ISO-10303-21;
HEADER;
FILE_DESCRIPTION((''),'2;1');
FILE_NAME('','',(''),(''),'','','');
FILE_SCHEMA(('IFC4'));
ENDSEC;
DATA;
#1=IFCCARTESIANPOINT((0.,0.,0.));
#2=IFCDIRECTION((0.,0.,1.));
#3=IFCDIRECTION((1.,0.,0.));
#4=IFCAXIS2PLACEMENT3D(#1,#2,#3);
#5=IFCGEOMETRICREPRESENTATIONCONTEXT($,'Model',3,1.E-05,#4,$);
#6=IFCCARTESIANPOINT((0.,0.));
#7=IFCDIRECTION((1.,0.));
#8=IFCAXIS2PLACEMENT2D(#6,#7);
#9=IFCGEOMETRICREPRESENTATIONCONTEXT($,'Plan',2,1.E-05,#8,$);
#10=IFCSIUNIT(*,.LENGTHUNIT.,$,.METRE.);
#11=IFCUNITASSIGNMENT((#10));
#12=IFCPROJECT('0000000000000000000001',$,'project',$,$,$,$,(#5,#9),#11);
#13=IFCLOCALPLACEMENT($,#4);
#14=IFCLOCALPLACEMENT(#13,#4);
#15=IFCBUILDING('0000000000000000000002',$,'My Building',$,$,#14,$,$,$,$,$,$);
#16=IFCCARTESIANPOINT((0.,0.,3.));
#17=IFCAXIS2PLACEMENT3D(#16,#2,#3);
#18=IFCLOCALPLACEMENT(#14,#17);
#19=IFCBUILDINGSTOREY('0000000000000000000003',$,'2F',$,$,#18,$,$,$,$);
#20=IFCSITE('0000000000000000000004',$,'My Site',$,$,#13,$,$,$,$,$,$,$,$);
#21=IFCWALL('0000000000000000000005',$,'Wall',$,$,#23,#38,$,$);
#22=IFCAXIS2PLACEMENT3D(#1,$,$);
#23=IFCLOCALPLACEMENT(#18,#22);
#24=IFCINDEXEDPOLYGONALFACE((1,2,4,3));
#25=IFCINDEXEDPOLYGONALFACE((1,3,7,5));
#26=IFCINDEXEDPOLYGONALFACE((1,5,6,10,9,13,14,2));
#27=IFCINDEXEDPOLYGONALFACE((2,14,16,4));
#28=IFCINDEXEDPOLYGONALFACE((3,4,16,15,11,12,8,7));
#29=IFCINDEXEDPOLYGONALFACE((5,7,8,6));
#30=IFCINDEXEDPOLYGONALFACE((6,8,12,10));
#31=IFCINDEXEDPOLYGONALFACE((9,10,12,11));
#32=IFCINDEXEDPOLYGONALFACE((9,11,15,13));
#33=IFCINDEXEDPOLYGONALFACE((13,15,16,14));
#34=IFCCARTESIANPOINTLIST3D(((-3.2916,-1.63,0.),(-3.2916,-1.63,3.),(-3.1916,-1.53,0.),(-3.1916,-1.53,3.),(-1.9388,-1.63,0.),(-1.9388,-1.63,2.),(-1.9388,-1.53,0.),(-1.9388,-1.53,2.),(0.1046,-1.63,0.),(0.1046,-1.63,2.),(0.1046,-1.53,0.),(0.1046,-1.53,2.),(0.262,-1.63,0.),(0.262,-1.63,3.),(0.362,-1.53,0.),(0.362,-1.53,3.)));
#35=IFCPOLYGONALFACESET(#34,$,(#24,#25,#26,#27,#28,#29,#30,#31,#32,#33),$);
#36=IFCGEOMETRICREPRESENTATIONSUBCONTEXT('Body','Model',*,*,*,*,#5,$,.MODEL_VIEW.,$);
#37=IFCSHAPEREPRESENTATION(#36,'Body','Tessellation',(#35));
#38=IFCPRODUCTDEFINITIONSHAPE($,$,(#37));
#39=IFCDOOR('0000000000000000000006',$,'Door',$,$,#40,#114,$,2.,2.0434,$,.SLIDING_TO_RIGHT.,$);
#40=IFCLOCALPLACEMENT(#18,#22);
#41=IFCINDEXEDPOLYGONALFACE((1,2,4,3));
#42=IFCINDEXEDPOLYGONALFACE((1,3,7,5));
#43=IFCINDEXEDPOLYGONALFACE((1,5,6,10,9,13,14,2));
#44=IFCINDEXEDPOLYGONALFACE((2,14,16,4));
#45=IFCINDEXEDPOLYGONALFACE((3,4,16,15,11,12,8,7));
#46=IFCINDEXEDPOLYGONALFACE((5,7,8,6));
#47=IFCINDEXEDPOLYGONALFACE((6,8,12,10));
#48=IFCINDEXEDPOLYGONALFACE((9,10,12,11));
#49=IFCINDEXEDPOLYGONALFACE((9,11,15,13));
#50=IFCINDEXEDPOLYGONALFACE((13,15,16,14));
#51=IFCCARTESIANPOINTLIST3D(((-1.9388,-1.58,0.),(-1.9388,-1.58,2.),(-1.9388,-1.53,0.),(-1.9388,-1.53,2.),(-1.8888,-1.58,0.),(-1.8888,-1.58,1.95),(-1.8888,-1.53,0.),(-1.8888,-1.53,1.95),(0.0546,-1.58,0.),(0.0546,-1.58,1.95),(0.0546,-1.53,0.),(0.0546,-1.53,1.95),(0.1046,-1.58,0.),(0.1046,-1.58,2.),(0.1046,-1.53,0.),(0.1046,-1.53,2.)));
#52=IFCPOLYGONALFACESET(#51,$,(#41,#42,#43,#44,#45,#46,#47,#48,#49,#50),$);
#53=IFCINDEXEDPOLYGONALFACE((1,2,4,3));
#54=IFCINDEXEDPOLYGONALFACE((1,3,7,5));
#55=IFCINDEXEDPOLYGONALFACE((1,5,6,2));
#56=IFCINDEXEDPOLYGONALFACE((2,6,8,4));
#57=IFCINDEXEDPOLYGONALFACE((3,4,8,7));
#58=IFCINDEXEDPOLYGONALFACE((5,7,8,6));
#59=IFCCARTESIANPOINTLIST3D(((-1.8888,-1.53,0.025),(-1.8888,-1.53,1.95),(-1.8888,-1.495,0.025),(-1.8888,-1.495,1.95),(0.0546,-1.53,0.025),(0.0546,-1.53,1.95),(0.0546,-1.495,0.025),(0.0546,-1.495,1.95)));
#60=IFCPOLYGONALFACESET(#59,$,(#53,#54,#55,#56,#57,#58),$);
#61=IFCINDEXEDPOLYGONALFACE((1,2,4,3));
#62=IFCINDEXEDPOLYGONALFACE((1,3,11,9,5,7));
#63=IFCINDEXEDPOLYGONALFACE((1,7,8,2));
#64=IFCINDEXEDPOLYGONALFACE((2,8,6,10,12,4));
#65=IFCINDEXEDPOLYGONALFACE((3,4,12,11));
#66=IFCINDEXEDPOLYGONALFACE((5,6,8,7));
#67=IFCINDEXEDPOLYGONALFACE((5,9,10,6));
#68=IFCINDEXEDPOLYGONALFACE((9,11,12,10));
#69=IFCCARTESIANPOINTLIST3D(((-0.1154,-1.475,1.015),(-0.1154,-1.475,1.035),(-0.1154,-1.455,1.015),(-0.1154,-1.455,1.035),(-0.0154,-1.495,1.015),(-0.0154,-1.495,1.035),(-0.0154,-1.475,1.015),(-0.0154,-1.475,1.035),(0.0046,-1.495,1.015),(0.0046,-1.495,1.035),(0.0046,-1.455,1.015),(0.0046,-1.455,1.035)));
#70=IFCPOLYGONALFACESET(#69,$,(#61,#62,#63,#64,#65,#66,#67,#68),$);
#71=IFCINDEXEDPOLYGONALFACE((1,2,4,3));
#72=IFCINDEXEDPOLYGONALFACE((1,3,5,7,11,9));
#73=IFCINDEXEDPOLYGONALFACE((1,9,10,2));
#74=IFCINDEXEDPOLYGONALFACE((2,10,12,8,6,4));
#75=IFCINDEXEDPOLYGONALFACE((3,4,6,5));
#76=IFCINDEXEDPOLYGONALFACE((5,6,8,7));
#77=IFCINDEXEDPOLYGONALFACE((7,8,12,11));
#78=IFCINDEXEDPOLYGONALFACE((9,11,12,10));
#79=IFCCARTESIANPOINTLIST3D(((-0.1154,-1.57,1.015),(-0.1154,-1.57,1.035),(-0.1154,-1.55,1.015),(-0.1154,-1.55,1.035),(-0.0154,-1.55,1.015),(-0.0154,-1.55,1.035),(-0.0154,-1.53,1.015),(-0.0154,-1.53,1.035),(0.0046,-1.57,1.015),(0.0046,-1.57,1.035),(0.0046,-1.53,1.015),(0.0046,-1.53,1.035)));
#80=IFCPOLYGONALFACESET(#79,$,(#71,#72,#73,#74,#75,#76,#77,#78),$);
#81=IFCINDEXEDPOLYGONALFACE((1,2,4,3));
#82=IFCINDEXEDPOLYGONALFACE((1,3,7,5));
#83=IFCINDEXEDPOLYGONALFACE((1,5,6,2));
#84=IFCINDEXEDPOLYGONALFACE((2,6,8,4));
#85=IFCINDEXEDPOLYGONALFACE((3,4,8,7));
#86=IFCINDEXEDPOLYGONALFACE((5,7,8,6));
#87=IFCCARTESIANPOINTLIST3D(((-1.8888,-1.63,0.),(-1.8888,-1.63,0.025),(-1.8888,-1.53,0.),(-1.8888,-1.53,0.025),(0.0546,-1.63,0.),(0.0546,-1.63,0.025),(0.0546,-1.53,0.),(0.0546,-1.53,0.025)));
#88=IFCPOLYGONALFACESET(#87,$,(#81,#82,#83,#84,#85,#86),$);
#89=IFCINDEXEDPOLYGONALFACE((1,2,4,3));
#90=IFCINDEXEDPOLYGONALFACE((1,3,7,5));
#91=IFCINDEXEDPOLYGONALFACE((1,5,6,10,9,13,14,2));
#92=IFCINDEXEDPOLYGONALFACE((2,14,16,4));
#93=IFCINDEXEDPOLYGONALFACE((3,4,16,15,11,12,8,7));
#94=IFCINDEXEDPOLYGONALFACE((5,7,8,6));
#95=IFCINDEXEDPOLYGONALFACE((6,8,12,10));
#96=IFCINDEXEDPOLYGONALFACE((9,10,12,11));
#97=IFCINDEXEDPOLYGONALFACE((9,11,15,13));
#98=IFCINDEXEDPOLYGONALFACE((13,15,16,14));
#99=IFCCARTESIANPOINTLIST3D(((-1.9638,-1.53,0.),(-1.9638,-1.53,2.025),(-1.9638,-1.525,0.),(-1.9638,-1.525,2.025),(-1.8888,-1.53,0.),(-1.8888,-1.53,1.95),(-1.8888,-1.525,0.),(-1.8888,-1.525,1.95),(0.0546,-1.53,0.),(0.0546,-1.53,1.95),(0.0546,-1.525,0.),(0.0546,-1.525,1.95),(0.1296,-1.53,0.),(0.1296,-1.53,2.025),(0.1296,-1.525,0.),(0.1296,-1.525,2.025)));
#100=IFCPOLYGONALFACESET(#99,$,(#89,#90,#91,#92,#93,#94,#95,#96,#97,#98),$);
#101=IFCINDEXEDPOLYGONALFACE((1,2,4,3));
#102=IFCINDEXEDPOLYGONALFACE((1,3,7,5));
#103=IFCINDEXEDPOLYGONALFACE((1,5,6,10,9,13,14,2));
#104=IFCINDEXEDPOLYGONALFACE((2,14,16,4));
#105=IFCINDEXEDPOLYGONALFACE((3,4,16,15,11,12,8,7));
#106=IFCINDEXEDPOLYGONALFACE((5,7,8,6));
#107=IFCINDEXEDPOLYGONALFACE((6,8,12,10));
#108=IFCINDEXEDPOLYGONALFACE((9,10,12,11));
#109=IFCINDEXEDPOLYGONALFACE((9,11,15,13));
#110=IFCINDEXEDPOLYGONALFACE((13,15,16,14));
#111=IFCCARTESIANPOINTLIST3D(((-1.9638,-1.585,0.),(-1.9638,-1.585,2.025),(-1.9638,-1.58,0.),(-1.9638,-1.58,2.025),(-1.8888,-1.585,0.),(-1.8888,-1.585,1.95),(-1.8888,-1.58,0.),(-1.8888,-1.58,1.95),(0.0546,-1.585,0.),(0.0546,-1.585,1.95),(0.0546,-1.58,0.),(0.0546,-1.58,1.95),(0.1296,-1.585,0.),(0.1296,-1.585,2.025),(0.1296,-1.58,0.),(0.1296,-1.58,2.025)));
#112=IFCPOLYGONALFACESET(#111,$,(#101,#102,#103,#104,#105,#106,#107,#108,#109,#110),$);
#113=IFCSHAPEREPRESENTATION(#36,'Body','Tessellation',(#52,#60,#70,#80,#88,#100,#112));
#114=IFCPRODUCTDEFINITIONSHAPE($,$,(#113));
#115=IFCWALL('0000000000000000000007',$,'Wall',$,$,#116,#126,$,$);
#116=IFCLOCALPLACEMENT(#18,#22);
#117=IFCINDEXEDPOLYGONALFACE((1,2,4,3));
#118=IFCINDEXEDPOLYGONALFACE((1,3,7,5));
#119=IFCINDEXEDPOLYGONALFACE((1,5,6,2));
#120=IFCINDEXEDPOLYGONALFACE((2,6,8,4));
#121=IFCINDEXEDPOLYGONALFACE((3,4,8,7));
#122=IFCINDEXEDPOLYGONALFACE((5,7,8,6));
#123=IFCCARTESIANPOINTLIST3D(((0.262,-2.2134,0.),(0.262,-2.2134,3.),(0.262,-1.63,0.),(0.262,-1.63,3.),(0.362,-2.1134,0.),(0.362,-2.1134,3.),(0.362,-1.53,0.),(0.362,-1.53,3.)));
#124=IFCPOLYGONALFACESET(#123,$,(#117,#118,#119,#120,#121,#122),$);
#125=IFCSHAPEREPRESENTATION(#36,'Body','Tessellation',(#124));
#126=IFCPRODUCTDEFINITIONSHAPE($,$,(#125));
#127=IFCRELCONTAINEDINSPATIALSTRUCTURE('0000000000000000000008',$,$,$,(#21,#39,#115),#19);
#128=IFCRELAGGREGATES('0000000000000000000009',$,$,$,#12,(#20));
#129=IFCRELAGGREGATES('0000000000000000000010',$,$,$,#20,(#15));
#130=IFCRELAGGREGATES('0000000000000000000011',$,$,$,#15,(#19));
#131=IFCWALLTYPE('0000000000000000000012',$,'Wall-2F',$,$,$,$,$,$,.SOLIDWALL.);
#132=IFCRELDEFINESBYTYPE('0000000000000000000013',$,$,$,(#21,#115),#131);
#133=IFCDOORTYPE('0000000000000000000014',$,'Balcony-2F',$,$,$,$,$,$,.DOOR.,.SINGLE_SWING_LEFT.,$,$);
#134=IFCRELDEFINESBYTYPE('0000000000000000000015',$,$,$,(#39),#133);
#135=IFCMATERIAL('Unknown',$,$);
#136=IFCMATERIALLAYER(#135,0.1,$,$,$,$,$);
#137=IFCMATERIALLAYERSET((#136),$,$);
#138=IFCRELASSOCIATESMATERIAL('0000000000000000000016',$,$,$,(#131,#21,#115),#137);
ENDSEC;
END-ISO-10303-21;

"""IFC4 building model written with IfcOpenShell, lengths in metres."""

from ifc_helpers import new_model, entity, si_unit, frame, origin_with_axes, origin_2d_with_axis, place, context, subcontext, project, spatial, line, indexed_curve, outline, extrude, shape, source, transform, mapped, material, layer, layer_set, layer_usage, type_object, type_shapes, element, fill, save


model = new_model("IFC4")

# Units and contexts
model_context = context("Model", 3, precision=1e-05, world=origin_with_axes())
plan_context = context("Plan", 2, precision=1e-05, world=origin_2d_with_axis())
body_context_1 = subcontext(model_context, "Body", "Model", "MODEL_VIEW")
body_context_2 = subcontext(plan_context, "Body", "Plan", "PLAN_VIEW")
ifc_project = project(units=[si_unit("LENGTHUNIT", "METRE")], contexts=[model_context, plan_context])

# Site, building, storey
site_placement = place(None, origin_with_axes())
site = spatial("IfcSite", under=ifc_project, at=site_placement, Name="My Site")
building_placement = place(site_placement, origin_with_axes())
building = spatial("IfcBuilding", under=site, at=building_placement, Name="My Building")
storey_placement = place(building_placement, frame((0.0, 0.0, 3.0), z_axis=(0.0, 0.0, 1.0), x_axis=(1.0, 0.0, 0.0)))
storey = spatial("IfcBuildingStorey", under=building, at=storey_placement, Name="2F")

# Shared definitions
ifc_material = material(Name="Unknown")
ifc_layer = layer(ifc_material, 0.1)
ifc_layer_set = layer_set([ifc_layer])
wall_type = type_object("IfcWallType", Name="Wall-2F", PredefinedType="SOLIDWALL", material=ifc_layer_set)

# Wall, opening, door
ifc_layer_usage_1 = layer_usage(ifc_layer_set, "AXIS2", "POSITIVE", 0.0)
wall_1_placement = place(storey_placement, frame((-3.2916, -1.63, 0.0), z_axis=(0.0, 0.0, 1.0), x_axis=(1.0, 0.0, 0.0)))
wall_1 = element("IfcWall", 1, at=wall_1_placement, inside=storey, type_object=wall_type, material=ifc_layer_usage_1, Name="Wall", context=body_context_1, shape_type="SweptSolid", body=[
    extrude(outline(indexed_curve([(0.0, 0.0), (0.1, 0.1), (3.6537, 0.1), (3.5537, 0.0)], segments=[line(1, 2, 3, 4, 1)])), origin_with_axes(), (0.0, 0.0, 1.0), 3.0),
])
shared_shape_1 = source(origin_with_axes(), body_context_1, "Body", "SweptSolid", [
    extrude(outline(indexed_curve([(0.0, 0.0), (2.0434, 0.0), (2.0434, 2.0), (0.0, 2.0)], segments=[line(1, 2, 3, 4, 1)])), frame((0.0, -0.6, 0.0), z_axis=(0.0, -1.0, 0.0), x_axis=(1.0, 0.0, 0.0)), (0.0, 0.0, -1.0), 1.2),
])
opening_1_placement = place(wall_1_placement, frame((3.3963, 0.1, 0.0), z_axis=(0.0, 0.0, 1.0), x_axis=(-1.0, 0.0, 0.0)))
opening_1 = element("IfcOpeningElement", 2, at=opening_1_placement, cuts=wall_1, PredefinedType="OPENING", context=body_context_1, shape_type="MappedRepresentation", body=[
    mapped(shared_shape_1, transform((0.0, 0.0, 0.0), x_axis=(1.0, 0.0, 0.0), y_axis=(0.0, 1.0, 0.0), z_axis=(0.0, 0.0, 1.0), scale=1.0)),
])
door_type_1 = type_object("IfcDoorType", Name="Balcony-2F", OperationType="SINGLE_SWING_LEFT", PredefinedType="DOOR")
shared_shape_2 = source(origin_with_axes(), body_context_1, "Body", "SweptSolid", [
    extrude(outline(indexed_curve([(0.0, 0.0), (0.0, 2.0), (2.0434, 2.0), (2.0434, 0.0), (1.9934, 0.0), (1.9934, 1.95), (0.05, 1.95), (0.05, 0.0)], segments=[line(1, 2, 3, 4, 5, 6, 7, 8, 1)])), frame((0.0, 0.0, 0.0), z_axis=(0.0, -1.0, 0.0), x_axis=(1.0, 0.0, 0.0)), (0.0, 0.0, -1.0), 0.05),
    extrude(outline(indexed_curve([(0.0, 0.0), (1.9434, 0.0), (1.9434, 0.035), (0.0, 0.035)], segments=[line(1, 2, 3, 4, 1)])), frame((0.05, -0.035, 0.025), z_axis=(0.0, 0.0, 1.0), x_axis=(1.0, 0.0, 0.0)), (0.0, 0.0, 1.0), 1.925),
    extrude(outline(indexed_curve([(0.0, 0.0), (0.0, -0.04), (0.12, -0.04), (0.12, -0.02), (0.02, -0.02), (0.02, 0.0)], segments=[line(1, 2, 3, 4, 5, 6, 1)])), frame((0.1, -0.035, 1.015), z_axis=(0.0, 0.0, 1.0), x_axis=(1.0, 0.0, 0.0)), (0.0, 0.0, 1.0), 0.02),
    extrude(outline(indexed_curve([(0.0, 0.0), (0.0, 0.04), (0.12, 0.04), (0.12, 0.02), (0.02, 0.02), (0.02, 0.0)], segments=[line(1, 2, 3, 4, 5, 6, 1)])), frame((0.1, 0.0, 1.015), z_axis=(0.0, 0.0, 1.0), x_axis=(1.0, 0.0, 0.0)), (0.0, 0.0, 1.0), 0.02),
    extrude(outline(indexed_curve([(0.0, 0.0), (1.9434, 0.0), (1.9434, 0.1), (0.0, 0.1)], segments=[line(1, 2, 3, 4, 1)])), frame((0.05, 0.0, 0.0), z_axis=(0.0, 0.0, 1.0), x_axis=(1.0, 0.0, 0.0)), (0.0, 0.0, 1.0), 0.025),
    extrude(outline(indexed_curve([(0.0, 0.0), (0.0, 2.025), (2.0934, 2.025), (2.0934, 0.0), (2.0184, 0.0), (2.0184, 1.95), (0.075, 1.95), (0.075, 0.0)], segments=[line(1, 2, 3, 4, 5, 6, 7, 8, 1)])), frame((-0.025, -0.005, 0.0), z_axis=(0.0, -1.0, 0.0), x_axis=(1.0, 0.0, 0.0)), (0.0, 0.0, -1.0), 0.005),
    extrude(outline(indexed_curve([(0.0, 0.0), (0.0, 2.025), (2.0934, 2.025), (2.0934, 0.0), (2.0184, 0.0), (2.0184, 1.95), (0.075, 1.95), (0.075, 0.0)], segments=[line(1, 2, 3, 4, 5, 6, 7, 8, 1)])), frame((-0.025, 0.05, 0.0), z_axis=(0.0, -1.0, 0.0), x_axis=(1.0, 0.0, 0.0)), (0.0, 0.0, -1.0), 0.005),
])
shared_shape_3 = source(origin_with_axes(), body_context_2, "Body", "Curve2D", [
    entity("IfcIndexedPolyCurve", entity("IfcCartesianPointList2D", [[0.0, 0.0], [0.05, 0.0], [0.05, 0.05], [0.0, 0.05]]), [entity("IfcLineIndex", [1, 2, 3, 4, 1])]),
    entity("IfcIndexedPolyCurve", entity("IfcCartesianPointList2D", [[2.0434, 0.0], [1.9934, 0.0], [1.9934, 0.05], [2.0434, 0.05]]), [entity("IfcLineIndex", [1, 2, 3, 4, 1])]),
    entity("IfcIndexedPolyCurve", entity("IfcCartesianPointList2D", [[2.965, -0.035], [1.0217, -0.035], [1.0217, 0.0], [2.965, 0.0]]), [entity("IfcLineIndex", [1, 2, 3, 4, 1])]),
])
type_shapes(door_type_1, [shared_shape_2, shared_shape_3])
door_1_placement = place(opening_1_placement, frame((0.0, 0.0, 0.0), z_axis=(0.0, 0.0, 1.0), x_axis=(1.0, 0.0, 0.0)))
door_1 = element("IfcDoor", 3, at=door_1_placement, inside=storey, type_object=door_type_1, Name="Door", OperationType="SLIDING_TO_RIGHT", OverallHeight=2.0, OverallWidth=2.0434, shapes=[
    shape(body_context_1, "Body", "MappedRepresentation", [mapped(shared_shape_2, transform((0.0, 0.0, 0.0), x_axis=(1.0, 0.0, 0.0), y_axis=(0.0, 1.0, 0.0), z_axis=(0.0, 0.0, 1.0), scale=1.0))]),
    shape(body_context_2, "Body", "MappedRepresentation", [mapped(shared_shape_3, transform((0.0, 0.0, 0.0), x_axis=(1.0, 0.0, 0.0), y_axis=(0.0, 1.0, 0.0), z_axis=(0.0, 0.0, 1.0), scale=1.0))]),
])
fill(opening_1, door_1)

# Wall
ifc_layer_usage_2 = layer_usage(ifc_layer_set, "AXIS2", "POSITIVE", 0.0)
wall_2_placement = place(storey_placement, frame((0.262, -1.63, 0.0), z_axis=(0.0, 0.0, 1.0), x_axis=(0.000001, -1.0, 0.0)))
element("IfcWall", 4, at=wall_2_placement, inside=storey, type_object=wall_type, material=ifc_layer_usage_2, Name="Wall", context=body_context_1, shape_type="SweptSolid", body=[
    extrude(outline(indexed_curve([(0.0, 0.0), (-0.1, 0.1), (0.4834, 0.1), (0.5834, 0.0)], segments=[line(1, 2, 3, 4, 1)])), origin_with_axes(), (0.0, 0.0, 1.0), 3.0),
])

save(model, "model.ifc")
